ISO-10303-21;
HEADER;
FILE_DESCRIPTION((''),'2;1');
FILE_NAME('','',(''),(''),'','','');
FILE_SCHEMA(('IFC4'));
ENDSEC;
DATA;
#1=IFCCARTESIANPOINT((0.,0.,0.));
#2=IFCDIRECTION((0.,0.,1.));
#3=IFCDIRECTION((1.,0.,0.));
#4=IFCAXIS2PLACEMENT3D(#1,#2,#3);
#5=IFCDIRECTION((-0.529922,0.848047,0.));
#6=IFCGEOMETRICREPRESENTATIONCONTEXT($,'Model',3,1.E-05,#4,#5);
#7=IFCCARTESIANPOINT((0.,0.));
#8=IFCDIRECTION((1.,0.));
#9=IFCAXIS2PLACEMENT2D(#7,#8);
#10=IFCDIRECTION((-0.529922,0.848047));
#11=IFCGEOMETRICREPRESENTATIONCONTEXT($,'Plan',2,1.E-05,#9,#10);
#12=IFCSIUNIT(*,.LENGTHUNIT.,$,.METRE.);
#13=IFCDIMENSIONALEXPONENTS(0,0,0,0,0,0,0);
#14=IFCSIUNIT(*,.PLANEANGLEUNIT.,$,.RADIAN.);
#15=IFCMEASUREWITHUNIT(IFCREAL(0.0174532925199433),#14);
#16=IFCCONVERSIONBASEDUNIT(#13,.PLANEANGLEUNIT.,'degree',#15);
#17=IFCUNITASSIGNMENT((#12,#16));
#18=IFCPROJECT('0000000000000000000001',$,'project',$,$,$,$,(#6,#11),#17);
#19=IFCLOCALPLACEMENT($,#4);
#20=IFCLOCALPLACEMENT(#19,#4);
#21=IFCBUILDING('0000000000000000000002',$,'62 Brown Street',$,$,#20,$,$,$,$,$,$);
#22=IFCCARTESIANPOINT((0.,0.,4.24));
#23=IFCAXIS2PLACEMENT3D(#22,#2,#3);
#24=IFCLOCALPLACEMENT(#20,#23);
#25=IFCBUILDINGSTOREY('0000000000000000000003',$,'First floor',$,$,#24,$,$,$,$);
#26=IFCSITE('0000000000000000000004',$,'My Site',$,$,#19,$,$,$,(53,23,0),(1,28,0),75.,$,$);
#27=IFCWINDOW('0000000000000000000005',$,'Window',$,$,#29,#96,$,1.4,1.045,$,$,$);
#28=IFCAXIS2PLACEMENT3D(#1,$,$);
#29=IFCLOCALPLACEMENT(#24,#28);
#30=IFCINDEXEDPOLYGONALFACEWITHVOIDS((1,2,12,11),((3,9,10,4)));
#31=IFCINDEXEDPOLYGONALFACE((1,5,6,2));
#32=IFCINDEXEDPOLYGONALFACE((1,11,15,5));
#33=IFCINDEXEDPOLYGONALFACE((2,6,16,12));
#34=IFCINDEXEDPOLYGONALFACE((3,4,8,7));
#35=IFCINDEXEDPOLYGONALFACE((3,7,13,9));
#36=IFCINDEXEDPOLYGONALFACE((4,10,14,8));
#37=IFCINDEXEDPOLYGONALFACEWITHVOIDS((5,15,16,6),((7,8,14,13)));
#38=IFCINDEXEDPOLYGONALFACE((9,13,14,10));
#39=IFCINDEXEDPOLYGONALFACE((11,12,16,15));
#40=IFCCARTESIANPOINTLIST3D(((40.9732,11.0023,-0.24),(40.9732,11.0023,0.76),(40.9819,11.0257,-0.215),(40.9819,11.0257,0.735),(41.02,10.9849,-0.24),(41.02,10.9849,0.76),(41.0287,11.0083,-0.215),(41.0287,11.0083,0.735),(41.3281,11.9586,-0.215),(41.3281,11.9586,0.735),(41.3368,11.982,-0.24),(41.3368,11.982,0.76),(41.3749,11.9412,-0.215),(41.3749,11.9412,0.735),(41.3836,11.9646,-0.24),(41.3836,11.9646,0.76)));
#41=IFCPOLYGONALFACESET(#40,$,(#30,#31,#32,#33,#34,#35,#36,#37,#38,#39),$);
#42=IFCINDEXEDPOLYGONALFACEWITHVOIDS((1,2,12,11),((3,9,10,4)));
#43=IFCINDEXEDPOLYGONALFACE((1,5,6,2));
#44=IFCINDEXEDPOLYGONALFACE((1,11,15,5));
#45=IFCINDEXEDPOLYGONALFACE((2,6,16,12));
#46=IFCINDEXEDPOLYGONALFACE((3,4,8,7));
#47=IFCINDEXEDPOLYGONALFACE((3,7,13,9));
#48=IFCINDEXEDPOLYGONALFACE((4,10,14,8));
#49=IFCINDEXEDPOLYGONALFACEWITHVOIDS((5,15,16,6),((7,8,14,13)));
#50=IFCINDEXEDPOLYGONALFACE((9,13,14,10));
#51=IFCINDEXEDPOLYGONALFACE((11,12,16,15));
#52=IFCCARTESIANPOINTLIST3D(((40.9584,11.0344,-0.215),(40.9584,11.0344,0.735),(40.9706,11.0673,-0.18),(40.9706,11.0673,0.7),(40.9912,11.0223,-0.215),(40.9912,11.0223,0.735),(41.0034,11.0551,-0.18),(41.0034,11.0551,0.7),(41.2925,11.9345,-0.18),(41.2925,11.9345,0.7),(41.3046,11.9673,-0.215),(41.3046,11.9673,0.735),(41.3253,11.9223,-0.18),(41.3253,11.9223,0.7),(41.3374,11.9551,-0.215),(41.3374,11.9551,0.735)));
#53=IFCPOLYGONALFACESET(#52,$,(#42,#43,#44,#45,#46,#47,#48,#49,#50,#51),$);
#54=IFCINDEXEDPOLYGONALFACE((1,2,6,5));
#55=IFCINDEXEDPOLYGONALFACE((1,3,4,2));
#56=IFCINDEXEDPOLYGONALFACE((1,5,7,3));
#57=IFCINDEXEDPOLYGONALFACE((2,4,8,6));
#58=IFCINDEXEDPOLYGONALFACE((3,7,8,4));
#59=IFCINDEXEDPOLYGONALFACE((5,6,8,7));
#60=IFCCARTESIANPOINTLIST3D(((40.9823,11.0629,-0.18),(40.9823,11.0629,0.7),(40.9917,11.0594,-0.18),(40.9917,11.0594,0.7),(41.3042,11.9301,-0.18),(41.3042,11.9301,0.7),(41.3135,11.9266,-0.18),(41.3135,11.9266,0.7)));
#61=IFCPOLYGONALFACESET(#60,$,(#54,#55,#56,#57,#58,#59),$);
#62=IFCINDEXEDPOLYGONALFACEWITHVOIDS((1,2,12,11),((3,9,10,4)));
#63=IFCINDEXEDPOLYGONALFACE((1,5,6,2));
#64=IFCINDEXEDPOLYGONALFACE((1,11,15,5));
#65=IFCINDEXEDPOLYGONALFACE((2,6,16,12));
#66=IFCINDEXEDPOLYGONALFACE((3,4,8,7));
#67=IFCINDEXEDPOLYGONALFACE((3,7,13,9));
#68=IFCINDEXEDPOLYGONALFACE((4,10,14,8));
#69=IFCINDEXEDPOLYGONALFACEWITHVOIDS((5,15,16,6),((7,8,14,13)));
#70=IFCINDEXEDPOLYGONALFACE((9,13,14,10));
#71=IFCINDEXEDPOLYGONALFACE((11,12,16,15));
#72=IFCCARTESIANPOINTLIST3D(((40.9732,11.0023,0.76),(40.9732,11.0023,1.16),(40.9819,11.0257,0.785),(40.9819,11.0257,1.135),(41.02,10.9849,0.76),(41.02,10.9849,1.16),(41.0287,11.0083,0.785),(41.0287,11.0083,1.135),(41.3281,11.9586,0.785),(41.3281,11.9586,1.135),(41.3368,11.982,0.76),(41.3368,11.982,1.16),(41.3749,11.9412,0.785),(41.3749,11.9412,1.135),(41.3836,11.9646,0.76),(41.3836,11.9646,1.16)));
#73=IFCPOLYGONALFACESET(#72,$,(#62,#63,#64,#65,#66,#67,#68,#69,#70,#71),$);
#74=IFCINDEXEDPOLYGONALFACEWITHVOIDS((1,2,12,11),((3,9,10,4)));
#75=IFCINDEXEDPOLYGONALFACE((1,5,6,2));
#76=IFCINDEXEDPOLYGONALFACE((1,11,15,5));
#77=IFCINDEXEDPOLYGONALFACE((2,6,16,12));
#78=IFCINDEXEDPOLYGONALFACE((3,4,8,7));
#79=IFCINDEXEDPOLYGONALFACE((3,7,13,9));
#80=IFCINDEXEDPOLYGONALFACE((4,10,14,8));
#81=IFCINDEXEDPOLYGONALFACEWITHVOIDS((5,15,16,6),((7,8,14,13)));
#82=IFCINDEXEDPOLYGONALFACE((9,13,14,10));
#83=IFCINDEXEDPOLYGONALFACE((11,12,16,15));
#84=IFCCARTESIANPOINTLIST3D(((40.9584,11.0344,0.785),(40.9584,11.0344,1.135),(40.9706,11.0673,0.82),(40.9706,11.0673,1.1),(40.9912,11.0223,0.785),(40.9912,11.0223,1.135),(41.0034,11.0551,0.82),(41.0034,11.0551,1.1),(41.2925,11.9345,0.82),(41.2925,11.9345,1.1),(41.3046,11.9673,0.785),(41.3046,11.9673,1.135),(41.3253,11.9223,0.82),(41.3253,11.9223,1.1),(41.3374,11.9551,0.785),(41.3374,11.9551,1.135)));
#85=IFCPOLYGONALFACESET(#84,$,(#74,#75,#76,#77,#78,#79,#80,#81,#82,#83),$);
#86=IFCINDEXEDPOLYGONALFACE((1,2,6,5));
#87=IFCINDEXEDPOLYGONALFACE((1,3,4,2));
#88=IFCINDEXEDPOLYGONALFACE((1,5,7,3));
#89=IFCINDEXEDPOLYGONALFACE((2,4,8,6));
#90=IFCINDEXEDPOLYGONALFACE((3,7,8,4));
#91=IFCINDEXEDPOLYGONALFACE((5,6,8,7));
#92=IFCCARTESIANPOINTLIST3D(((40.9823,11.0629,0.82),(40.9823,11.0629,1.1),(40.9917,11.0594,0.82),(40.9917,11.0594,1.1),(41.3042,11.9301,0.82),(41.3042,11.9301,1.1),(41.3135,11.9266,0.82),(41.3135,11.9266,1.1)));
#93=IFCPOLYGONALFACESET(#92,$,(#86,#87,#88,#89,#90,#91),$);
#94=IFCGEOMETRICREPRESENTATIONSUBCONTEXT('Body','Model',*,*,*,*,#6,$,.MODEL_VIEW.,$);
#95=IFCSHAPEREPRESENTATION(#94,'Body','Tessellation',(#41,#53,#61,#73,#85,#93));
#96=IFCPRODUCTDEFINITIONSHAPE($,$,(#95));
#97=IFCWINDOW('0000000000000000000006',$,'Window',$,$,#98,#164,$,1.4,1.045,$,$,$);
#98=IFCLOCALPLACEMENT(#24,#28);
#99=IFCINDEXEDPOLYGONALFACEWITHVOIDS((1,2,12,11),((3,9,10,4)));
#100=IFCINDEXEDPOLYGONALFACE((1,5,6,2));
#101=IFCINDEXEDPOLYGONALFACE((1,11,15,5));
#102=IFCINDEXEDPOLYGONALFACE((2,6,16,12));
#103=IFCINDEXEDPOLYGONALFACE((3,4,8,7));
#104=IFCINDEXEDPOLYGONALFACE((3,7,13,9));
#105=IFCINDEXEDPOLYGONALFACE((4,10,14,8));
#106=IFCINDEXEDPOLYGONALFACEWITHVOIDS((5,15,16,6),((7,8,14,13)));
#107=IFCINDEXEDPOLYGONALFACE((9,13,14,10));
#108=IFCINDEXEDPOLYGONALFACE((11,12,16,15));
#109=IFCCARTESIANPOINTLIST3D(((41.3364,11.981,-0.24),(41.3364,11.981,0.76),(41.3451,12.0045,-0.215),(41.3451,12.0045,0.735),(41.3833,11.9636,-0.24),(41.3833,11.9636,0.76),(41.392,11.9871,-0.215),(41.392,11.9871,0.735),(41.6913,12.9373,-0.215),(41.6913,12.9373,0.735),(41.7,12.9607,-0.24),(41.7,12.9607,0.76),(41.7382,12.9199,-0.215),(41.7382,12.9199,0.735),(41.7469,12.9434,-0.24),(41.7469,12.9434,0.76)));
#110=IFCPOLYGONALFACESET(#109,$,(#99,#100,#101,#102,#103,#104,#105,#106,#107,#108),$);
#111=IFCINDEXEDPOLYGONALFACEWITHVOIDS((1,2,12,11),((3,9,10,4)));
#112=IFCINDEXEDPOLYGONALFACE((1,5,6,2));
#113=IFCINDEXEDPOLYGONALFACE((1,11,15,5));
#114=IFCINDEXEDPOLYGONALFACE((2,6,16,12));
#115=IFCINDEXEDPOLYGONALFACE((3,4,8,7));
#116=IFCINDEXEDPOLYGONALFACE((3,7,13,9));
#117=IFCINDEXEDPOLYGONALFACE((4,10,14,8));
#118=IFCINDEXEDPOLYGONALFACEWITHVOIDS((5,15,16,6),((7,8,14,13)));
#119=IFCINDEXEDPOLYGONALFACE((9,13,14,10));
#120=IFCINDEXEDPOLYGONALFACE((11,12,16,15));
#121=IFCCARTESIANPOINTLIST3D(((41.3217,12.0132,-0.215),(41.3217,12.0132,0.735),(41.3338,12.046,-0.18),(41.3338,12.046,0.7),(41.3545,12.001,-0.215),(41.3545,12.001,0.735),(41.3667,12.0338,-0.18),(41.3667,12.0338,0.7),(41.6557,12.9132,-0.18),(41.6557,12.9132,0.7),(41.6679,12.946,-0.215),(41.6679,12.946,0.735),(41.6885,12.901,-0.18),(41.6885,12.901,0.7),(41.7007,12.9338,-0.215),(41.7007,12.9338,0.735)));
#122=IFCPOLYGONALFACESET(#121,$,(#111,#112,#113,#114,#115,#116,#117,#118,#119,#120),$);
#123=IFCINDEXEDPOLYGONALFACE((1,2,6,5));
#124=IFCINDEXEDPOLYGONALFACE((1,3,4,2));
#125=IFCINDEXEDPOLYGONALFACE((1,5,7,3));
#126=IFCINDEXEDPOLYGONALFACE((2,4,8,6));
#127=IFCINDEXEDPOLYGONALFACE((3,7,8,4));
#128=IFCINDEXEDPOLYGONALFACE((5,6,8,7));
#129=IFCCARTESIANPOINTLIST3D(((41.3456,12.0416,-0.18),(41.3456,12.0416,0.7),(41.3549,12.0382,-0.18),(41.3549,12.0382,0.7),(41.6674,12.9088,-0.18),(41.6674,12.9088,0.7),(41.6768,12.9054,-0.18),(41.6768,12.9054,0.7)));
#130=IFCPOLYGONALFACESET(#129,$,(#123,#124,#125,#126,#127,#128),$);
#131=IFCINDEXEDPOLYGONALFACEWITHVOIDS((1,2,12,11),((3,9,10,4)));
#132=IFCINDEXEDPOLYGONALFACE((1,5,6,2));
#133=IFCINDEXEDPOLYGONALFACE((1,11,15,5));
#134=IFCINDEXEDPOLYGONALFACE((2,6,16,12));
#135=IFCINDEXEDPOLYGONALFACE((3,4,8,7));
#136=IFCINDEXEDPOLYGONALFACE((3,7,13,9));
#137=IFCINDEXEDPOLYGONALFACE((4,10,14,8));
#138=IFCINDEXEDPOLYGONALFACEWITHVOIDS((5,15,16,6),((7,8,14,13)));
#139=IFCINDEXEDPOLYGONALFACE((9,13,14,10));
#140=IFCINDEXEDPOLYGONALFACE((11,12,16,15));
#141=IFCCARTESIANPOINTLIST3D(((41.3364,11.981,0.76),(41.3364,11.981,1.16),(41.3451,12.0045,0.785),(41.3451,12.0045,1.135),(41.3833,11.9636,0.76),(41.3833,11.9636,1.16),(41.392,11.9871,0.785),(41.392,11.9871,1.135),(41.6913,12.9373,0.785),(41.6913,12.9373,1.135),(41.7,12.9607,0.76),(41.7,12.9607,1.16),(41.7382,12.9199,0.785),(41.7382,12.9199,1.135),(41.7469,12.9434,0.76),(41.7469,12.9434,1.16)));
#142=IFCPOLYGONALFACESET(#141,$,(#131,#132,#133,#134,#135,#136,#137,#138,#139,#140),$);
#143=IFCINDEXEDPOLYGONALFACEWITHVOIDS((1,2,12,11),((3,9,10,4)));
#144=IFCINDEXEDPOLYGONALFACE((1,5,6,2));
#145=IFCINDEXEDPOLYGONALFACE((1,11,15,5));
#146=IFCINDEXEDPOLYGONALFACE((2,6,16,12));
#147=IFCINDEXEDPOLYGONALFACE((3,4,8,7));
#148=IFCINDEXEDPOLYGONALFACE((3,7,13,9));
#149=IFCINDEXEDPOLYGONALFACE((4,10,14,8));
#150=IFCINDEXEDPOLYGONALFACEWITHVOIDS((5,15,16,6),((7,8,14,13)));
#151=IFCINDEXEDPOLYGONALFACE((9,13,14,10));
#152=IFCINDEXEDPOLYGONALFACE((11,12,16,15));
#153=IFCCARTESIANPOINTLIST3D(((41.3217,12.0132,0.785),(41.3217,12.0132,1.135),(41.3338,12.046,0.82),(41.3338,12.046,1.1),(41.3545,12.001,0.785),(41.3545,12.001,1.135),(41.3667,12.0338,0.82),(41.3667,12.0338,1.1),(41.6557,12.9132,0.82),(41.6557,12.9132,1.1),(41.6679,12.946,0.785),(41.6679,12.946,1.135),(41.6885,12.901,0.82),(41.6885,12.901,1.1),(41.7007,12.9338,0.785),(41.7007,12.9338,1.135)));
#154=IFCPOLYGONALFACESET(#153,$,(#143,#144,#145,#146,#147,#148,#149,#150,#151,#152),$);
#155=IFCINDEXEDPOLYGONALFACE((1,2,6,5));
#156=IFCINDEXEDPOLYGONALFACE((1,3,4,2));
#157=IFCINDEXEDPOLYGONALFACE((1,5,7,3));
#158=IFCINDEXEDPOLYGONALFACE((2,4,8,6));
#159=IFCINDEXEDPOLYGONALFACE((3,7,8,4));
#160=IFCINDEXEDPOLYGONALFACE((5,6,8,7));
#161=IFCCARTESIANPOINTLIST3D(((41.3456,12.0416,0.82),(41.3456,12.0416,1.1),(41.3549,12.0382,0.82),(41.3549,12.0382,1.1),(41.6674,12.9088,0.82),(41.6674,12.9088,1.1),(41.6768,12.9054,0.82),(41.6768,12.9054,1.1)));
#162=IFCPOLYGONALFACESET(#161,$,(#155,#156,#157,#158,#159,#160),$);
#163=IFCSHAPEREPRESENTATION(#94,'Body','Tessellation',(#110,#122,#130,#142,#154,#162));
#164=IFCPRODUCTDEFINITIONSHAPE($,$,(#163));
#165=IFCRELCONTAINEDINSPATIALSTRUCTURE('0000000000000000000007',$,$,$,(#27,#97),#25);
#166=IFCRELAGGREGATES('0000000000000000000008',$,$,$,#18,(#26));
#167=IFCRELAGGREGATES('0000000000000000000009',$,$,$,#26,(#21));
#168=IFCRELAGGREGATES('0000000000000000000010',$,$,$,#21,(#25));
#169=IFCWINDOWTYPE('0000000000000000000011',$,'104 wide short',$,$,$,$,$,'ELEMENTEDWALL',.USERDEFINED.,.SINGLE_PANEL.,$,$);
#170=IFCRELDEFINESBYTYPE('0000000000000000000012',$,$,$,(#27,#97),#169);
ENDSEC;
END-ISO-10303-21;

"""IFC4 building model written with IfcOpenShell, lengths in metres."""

from ifc_helpers import new_model, entity, si_unit, converted_unit, direction, frame, origin_with_axes, origin_2d_with_axis, place, context, subcontext, project, spatial, line, indexed_curve, outline, extrude, shape, source, transform, mapped, type_object, type_shapes, element, save


model = new_model("IFC4")

# Units and contexts
model_context = context("Model", 3, precision=1e-05, world=origin_with_axes(), true_north=direction((-0.529922, 0.848047, 0.0)))
plan_context = context("Plan", 2, precision=1e-05, world=origin_2d_with_axis(), true_north=direction((-0.529922, 0.848047)))
body_context_1 = subcontext(model_context, "Body", "Model", "MODEL_VIEW")
body_context_2 = subcontext(plan_context, "Body", "Plan", "PLAN_VIEW")
ifc_project = project(units=[si_unit("LENGTHUNIT", "METRE"), converted_unit("PLANEANGLEUNIT", "degree", entity("IfcReal", 0.0174532925199433), si_unit("PLANEANGLEUNIT", "RADIAN"), dimensions=[0, 0, 0, 0, 0, 0, 0])], contexts=[model_context, plan_context])

# Site, building, storey
site_placement = place(None, origin_with_axes())
site = spatial("IfcSite", under=ifc_project, at=site_placement, Name="My Site", RefLatitude=(53, 23, 0), RefLongitude=(1, 28, 0), RefElevation=75.0)
building_placement = place(site_placement, origin_with_axes())
building = spatial("IfcBuilding", under=site, at=building_placement, Name="62 Brown Street")
storey_placement = place(building_placement, frame((0.0, 0.0, 4.24), z_axis=(0.0, 0.0, 1.0), x_axis=(1.0, 0.0, 0.0)))
storey = spatial("IfcBuildingStorey", under=building, at=storey_placement, Name="First floor")

# Shared definitions
window_type_1 = type_object("IfcWindowType", Name="104 wide short", ElementType="ELEMENTEDWALL", PartitioningType="SINGLE_PANEL", PredefinedType="USERDEFINED")
shared_shape_1 = source(origin_with_axes(), body_context_1, "Body", "SweptSolid", [
    extrude(outline(indexed_curve([(0.0, 0.0), (1.045, 0.0), (1.045, 1.0), (0.0, 1.0)], segments=[line(1, 2, 3, 4, 1)]), holes=[indexed_curve([(0.025, 0.025), (1.02, 0.025), (1.02, 0.975), (0.025, 0.975)], segments=[line(1, 2, 3, 4, 1)])]), frame((0.0, 0.15, 0.0), z_axis=(0.0, -1.0, 0.0), x_axis=(1.0, 0.0, 0.0)), (0.0, 0.0, -1.0), 0.05),
    extrude(outline(indexed_curve([(0.0, 0.0), (0.995, 0.0), (0.995, 0.95), (0.0, 0.95)], segments=[line(1, 2, 3, 4, 1)]), holes=[indexed_curve([(0.035, 0.035), (0.96, 0.035), (0.96, 0.915), (0.035, 0.915)], segments=[line(1, 2, 3, 4, 1)])]), frame((0.025, 0.19, 0.025), z_axis=(0.0, -1.0, 0.0), x_axis=(1.0, 0.0, 0.0)), (0.0, 0.0, -1.0), 0.035),
    extrude(outline(indexed_curve([(0.035, 0.035), (0.96, 0.035), (0.96, 0.915), (0.035, 0.915)], segments=[line(1, 2, 3, 4, 1)])), frame((0.025, 0.2025, 0.025), z_axis=(0.0, -1.0, 0.0), x_axis=(1.0, 0.0, 0.0)), (0.0, 0.0, -1.0), 0.01),
    extrude(outline(indexed_curve([(0.0, 0.0), (1.045, 0.0), (1.045, 0.4), (0.0, 0.4)], segments=[line(1, 2, 3, 4, 1)]), holes=[indexed_curve([(0.025, 0.025), (1.02, 0.025), (1.02, 0.375), (0.025, 0.375)], segments=[line(1, 2, 3, 4, 1)])]), frame((0.0, 0.15, 1.0), z_axis=(0.0, -1.0, 0.0), x_axis=(1.0, 0.0, 0.0)), (0.0, 0.0, -1.0), 0.05),
    extrude(outline(indexed_curve([(0.0, 0.0), (0.995, 0.0), (0.995, 0.35), (0.0, 0.35)], segments=[line(1, 2, 3, 4, 1)]), holes=[indexed_curve([(0.035, 0.035), (0.96, 0.035), (0.96, 0.315), (0.035, 0.315)], segments=[line(1, 2, 3, 4, 1)])]), frame((0.025, 0.19, 1.025), z_axis=(0.0, -1.0, 0.0), x_axis=(1.0, 0.0, 0.0)), (0.0, 0.0, -1.0), 0.035),
    extrude(outline(indexed_curve([(0.035, 0.035), (0.96, 0.035), (0.96, 0.315), (0.035, 0.315)], segments=[line(1, 2, 3, 4, 1)])), frame((0.025, 0.2025, 1.025), z_axis=(0.0, -1.0, 0.0), x_axis=(1.0, 0.0, 0.0)), (0.0, 0.0, -1.0), 0.01),
])
shared_shape_2 = source(origin_with_axes(), body_context_2, "Body", "Curve2D", [
    entity("IfcIndexedPolyCurve", entity("IfcCartesianPointList2D", [[0.025, 0.15], [1.02, 0.15]])),
    entity("IfcIndexedPolyCurve", entity("IfcCartesianPointList2D", [[0.0, 0.2], [0.025, 0.2], [0.025, 0.15], [0.0, 0.15]]), [entity("IfcLineIndex", [1, 2, 3, 4, 1])]),
    entity("IfcIndexedPolyCurve", entity("IfcCartesianPointList2D", [[1.045, 0.2], [1.02, 0.2], [1.02, 0.15], [1.045, 0.15]]), [entity("IfcLineIndex", [1, 2, 3, 4, 1])]),
    entity("IfcIndexedPolyCurve", entity("IfcCartesianPointList2D", [[0.025, 0.19], [0.06, 0.19], [0.06, 0.225], [0.025, 0.225]]), [entity("IfcLineIndex", [1, 2, 3, 4, 1])]),
    entity("IfcIndexedPolyCurve", entity("IfcCartesianPointList2D", [[1.02, 0.19], [0.985, 0.19], [0.985, 0.225], [1.02, 0.225]]), [entity("IfcLineIndex", [1, 2, 3, 4, 1])]),
    entity("IfcIndexedPolyCurve", entity("IfcCartesianPointList2D", [[0.06, 0.19], [0.985, 0.19]])),
    entity("IfcIndexedPolyCurve", entity("IfcCartesianPointList2D", [[0.06, 0.225], [0.985, 0.225]])),
    entity("IfcIndexedPolyCurve", entity("IfcCartesianPointList2D", [[0.06, 0.2075], [0.985, 0.2075]])),
])
type_shapes(window_type_1, [shared_shape_1, shared_shape_2])

# Windows
for number, where, z_axis, x_axis, name in (
    (1, (41.1607, 10.9327, -0.24), (0.0, 0.0, 1.0), (0.347944, 0.937515, 0.0), "Window"),
    (2, (41.5239, 11.9115, -0.24), (0.0, 0.0, 1.0), (0.347944, 0.937515, 0.0), "Window"),
):
    element("IfcWindow", number, at=place(storey_placement, frame(where, z_axis=z_axis, x_axis=x_axis)), inside=storey, type_object=window_type_1, Name=name, OverallHeight=1.4, OverallWidth=1.045, shapes=[
        shape(body_context_1, "Body", "MappedRepresentation", [mapped(shared_shape_1, transform((0.0, 0.0, 0.0), x_axis=(1.0, 0.0, 0.0), y_axis=(0.0, 1.0, 0.0), z_axis=(0.0, 0.0, 1.0), scale=1.0))]),
        shape(body_context_2, "Body", "MappedRepresentation", [mapped(shared_shape_2, transform((0.0, 0.0, 0.0), x_axis=(1.0, 0.0, 0.0), y_axis=(0.0, 1.0, 0.0), z_axis=(0.0, 0.0, 1.0), scale=1.0))]),
    ])

save(model, "model.ifc")
